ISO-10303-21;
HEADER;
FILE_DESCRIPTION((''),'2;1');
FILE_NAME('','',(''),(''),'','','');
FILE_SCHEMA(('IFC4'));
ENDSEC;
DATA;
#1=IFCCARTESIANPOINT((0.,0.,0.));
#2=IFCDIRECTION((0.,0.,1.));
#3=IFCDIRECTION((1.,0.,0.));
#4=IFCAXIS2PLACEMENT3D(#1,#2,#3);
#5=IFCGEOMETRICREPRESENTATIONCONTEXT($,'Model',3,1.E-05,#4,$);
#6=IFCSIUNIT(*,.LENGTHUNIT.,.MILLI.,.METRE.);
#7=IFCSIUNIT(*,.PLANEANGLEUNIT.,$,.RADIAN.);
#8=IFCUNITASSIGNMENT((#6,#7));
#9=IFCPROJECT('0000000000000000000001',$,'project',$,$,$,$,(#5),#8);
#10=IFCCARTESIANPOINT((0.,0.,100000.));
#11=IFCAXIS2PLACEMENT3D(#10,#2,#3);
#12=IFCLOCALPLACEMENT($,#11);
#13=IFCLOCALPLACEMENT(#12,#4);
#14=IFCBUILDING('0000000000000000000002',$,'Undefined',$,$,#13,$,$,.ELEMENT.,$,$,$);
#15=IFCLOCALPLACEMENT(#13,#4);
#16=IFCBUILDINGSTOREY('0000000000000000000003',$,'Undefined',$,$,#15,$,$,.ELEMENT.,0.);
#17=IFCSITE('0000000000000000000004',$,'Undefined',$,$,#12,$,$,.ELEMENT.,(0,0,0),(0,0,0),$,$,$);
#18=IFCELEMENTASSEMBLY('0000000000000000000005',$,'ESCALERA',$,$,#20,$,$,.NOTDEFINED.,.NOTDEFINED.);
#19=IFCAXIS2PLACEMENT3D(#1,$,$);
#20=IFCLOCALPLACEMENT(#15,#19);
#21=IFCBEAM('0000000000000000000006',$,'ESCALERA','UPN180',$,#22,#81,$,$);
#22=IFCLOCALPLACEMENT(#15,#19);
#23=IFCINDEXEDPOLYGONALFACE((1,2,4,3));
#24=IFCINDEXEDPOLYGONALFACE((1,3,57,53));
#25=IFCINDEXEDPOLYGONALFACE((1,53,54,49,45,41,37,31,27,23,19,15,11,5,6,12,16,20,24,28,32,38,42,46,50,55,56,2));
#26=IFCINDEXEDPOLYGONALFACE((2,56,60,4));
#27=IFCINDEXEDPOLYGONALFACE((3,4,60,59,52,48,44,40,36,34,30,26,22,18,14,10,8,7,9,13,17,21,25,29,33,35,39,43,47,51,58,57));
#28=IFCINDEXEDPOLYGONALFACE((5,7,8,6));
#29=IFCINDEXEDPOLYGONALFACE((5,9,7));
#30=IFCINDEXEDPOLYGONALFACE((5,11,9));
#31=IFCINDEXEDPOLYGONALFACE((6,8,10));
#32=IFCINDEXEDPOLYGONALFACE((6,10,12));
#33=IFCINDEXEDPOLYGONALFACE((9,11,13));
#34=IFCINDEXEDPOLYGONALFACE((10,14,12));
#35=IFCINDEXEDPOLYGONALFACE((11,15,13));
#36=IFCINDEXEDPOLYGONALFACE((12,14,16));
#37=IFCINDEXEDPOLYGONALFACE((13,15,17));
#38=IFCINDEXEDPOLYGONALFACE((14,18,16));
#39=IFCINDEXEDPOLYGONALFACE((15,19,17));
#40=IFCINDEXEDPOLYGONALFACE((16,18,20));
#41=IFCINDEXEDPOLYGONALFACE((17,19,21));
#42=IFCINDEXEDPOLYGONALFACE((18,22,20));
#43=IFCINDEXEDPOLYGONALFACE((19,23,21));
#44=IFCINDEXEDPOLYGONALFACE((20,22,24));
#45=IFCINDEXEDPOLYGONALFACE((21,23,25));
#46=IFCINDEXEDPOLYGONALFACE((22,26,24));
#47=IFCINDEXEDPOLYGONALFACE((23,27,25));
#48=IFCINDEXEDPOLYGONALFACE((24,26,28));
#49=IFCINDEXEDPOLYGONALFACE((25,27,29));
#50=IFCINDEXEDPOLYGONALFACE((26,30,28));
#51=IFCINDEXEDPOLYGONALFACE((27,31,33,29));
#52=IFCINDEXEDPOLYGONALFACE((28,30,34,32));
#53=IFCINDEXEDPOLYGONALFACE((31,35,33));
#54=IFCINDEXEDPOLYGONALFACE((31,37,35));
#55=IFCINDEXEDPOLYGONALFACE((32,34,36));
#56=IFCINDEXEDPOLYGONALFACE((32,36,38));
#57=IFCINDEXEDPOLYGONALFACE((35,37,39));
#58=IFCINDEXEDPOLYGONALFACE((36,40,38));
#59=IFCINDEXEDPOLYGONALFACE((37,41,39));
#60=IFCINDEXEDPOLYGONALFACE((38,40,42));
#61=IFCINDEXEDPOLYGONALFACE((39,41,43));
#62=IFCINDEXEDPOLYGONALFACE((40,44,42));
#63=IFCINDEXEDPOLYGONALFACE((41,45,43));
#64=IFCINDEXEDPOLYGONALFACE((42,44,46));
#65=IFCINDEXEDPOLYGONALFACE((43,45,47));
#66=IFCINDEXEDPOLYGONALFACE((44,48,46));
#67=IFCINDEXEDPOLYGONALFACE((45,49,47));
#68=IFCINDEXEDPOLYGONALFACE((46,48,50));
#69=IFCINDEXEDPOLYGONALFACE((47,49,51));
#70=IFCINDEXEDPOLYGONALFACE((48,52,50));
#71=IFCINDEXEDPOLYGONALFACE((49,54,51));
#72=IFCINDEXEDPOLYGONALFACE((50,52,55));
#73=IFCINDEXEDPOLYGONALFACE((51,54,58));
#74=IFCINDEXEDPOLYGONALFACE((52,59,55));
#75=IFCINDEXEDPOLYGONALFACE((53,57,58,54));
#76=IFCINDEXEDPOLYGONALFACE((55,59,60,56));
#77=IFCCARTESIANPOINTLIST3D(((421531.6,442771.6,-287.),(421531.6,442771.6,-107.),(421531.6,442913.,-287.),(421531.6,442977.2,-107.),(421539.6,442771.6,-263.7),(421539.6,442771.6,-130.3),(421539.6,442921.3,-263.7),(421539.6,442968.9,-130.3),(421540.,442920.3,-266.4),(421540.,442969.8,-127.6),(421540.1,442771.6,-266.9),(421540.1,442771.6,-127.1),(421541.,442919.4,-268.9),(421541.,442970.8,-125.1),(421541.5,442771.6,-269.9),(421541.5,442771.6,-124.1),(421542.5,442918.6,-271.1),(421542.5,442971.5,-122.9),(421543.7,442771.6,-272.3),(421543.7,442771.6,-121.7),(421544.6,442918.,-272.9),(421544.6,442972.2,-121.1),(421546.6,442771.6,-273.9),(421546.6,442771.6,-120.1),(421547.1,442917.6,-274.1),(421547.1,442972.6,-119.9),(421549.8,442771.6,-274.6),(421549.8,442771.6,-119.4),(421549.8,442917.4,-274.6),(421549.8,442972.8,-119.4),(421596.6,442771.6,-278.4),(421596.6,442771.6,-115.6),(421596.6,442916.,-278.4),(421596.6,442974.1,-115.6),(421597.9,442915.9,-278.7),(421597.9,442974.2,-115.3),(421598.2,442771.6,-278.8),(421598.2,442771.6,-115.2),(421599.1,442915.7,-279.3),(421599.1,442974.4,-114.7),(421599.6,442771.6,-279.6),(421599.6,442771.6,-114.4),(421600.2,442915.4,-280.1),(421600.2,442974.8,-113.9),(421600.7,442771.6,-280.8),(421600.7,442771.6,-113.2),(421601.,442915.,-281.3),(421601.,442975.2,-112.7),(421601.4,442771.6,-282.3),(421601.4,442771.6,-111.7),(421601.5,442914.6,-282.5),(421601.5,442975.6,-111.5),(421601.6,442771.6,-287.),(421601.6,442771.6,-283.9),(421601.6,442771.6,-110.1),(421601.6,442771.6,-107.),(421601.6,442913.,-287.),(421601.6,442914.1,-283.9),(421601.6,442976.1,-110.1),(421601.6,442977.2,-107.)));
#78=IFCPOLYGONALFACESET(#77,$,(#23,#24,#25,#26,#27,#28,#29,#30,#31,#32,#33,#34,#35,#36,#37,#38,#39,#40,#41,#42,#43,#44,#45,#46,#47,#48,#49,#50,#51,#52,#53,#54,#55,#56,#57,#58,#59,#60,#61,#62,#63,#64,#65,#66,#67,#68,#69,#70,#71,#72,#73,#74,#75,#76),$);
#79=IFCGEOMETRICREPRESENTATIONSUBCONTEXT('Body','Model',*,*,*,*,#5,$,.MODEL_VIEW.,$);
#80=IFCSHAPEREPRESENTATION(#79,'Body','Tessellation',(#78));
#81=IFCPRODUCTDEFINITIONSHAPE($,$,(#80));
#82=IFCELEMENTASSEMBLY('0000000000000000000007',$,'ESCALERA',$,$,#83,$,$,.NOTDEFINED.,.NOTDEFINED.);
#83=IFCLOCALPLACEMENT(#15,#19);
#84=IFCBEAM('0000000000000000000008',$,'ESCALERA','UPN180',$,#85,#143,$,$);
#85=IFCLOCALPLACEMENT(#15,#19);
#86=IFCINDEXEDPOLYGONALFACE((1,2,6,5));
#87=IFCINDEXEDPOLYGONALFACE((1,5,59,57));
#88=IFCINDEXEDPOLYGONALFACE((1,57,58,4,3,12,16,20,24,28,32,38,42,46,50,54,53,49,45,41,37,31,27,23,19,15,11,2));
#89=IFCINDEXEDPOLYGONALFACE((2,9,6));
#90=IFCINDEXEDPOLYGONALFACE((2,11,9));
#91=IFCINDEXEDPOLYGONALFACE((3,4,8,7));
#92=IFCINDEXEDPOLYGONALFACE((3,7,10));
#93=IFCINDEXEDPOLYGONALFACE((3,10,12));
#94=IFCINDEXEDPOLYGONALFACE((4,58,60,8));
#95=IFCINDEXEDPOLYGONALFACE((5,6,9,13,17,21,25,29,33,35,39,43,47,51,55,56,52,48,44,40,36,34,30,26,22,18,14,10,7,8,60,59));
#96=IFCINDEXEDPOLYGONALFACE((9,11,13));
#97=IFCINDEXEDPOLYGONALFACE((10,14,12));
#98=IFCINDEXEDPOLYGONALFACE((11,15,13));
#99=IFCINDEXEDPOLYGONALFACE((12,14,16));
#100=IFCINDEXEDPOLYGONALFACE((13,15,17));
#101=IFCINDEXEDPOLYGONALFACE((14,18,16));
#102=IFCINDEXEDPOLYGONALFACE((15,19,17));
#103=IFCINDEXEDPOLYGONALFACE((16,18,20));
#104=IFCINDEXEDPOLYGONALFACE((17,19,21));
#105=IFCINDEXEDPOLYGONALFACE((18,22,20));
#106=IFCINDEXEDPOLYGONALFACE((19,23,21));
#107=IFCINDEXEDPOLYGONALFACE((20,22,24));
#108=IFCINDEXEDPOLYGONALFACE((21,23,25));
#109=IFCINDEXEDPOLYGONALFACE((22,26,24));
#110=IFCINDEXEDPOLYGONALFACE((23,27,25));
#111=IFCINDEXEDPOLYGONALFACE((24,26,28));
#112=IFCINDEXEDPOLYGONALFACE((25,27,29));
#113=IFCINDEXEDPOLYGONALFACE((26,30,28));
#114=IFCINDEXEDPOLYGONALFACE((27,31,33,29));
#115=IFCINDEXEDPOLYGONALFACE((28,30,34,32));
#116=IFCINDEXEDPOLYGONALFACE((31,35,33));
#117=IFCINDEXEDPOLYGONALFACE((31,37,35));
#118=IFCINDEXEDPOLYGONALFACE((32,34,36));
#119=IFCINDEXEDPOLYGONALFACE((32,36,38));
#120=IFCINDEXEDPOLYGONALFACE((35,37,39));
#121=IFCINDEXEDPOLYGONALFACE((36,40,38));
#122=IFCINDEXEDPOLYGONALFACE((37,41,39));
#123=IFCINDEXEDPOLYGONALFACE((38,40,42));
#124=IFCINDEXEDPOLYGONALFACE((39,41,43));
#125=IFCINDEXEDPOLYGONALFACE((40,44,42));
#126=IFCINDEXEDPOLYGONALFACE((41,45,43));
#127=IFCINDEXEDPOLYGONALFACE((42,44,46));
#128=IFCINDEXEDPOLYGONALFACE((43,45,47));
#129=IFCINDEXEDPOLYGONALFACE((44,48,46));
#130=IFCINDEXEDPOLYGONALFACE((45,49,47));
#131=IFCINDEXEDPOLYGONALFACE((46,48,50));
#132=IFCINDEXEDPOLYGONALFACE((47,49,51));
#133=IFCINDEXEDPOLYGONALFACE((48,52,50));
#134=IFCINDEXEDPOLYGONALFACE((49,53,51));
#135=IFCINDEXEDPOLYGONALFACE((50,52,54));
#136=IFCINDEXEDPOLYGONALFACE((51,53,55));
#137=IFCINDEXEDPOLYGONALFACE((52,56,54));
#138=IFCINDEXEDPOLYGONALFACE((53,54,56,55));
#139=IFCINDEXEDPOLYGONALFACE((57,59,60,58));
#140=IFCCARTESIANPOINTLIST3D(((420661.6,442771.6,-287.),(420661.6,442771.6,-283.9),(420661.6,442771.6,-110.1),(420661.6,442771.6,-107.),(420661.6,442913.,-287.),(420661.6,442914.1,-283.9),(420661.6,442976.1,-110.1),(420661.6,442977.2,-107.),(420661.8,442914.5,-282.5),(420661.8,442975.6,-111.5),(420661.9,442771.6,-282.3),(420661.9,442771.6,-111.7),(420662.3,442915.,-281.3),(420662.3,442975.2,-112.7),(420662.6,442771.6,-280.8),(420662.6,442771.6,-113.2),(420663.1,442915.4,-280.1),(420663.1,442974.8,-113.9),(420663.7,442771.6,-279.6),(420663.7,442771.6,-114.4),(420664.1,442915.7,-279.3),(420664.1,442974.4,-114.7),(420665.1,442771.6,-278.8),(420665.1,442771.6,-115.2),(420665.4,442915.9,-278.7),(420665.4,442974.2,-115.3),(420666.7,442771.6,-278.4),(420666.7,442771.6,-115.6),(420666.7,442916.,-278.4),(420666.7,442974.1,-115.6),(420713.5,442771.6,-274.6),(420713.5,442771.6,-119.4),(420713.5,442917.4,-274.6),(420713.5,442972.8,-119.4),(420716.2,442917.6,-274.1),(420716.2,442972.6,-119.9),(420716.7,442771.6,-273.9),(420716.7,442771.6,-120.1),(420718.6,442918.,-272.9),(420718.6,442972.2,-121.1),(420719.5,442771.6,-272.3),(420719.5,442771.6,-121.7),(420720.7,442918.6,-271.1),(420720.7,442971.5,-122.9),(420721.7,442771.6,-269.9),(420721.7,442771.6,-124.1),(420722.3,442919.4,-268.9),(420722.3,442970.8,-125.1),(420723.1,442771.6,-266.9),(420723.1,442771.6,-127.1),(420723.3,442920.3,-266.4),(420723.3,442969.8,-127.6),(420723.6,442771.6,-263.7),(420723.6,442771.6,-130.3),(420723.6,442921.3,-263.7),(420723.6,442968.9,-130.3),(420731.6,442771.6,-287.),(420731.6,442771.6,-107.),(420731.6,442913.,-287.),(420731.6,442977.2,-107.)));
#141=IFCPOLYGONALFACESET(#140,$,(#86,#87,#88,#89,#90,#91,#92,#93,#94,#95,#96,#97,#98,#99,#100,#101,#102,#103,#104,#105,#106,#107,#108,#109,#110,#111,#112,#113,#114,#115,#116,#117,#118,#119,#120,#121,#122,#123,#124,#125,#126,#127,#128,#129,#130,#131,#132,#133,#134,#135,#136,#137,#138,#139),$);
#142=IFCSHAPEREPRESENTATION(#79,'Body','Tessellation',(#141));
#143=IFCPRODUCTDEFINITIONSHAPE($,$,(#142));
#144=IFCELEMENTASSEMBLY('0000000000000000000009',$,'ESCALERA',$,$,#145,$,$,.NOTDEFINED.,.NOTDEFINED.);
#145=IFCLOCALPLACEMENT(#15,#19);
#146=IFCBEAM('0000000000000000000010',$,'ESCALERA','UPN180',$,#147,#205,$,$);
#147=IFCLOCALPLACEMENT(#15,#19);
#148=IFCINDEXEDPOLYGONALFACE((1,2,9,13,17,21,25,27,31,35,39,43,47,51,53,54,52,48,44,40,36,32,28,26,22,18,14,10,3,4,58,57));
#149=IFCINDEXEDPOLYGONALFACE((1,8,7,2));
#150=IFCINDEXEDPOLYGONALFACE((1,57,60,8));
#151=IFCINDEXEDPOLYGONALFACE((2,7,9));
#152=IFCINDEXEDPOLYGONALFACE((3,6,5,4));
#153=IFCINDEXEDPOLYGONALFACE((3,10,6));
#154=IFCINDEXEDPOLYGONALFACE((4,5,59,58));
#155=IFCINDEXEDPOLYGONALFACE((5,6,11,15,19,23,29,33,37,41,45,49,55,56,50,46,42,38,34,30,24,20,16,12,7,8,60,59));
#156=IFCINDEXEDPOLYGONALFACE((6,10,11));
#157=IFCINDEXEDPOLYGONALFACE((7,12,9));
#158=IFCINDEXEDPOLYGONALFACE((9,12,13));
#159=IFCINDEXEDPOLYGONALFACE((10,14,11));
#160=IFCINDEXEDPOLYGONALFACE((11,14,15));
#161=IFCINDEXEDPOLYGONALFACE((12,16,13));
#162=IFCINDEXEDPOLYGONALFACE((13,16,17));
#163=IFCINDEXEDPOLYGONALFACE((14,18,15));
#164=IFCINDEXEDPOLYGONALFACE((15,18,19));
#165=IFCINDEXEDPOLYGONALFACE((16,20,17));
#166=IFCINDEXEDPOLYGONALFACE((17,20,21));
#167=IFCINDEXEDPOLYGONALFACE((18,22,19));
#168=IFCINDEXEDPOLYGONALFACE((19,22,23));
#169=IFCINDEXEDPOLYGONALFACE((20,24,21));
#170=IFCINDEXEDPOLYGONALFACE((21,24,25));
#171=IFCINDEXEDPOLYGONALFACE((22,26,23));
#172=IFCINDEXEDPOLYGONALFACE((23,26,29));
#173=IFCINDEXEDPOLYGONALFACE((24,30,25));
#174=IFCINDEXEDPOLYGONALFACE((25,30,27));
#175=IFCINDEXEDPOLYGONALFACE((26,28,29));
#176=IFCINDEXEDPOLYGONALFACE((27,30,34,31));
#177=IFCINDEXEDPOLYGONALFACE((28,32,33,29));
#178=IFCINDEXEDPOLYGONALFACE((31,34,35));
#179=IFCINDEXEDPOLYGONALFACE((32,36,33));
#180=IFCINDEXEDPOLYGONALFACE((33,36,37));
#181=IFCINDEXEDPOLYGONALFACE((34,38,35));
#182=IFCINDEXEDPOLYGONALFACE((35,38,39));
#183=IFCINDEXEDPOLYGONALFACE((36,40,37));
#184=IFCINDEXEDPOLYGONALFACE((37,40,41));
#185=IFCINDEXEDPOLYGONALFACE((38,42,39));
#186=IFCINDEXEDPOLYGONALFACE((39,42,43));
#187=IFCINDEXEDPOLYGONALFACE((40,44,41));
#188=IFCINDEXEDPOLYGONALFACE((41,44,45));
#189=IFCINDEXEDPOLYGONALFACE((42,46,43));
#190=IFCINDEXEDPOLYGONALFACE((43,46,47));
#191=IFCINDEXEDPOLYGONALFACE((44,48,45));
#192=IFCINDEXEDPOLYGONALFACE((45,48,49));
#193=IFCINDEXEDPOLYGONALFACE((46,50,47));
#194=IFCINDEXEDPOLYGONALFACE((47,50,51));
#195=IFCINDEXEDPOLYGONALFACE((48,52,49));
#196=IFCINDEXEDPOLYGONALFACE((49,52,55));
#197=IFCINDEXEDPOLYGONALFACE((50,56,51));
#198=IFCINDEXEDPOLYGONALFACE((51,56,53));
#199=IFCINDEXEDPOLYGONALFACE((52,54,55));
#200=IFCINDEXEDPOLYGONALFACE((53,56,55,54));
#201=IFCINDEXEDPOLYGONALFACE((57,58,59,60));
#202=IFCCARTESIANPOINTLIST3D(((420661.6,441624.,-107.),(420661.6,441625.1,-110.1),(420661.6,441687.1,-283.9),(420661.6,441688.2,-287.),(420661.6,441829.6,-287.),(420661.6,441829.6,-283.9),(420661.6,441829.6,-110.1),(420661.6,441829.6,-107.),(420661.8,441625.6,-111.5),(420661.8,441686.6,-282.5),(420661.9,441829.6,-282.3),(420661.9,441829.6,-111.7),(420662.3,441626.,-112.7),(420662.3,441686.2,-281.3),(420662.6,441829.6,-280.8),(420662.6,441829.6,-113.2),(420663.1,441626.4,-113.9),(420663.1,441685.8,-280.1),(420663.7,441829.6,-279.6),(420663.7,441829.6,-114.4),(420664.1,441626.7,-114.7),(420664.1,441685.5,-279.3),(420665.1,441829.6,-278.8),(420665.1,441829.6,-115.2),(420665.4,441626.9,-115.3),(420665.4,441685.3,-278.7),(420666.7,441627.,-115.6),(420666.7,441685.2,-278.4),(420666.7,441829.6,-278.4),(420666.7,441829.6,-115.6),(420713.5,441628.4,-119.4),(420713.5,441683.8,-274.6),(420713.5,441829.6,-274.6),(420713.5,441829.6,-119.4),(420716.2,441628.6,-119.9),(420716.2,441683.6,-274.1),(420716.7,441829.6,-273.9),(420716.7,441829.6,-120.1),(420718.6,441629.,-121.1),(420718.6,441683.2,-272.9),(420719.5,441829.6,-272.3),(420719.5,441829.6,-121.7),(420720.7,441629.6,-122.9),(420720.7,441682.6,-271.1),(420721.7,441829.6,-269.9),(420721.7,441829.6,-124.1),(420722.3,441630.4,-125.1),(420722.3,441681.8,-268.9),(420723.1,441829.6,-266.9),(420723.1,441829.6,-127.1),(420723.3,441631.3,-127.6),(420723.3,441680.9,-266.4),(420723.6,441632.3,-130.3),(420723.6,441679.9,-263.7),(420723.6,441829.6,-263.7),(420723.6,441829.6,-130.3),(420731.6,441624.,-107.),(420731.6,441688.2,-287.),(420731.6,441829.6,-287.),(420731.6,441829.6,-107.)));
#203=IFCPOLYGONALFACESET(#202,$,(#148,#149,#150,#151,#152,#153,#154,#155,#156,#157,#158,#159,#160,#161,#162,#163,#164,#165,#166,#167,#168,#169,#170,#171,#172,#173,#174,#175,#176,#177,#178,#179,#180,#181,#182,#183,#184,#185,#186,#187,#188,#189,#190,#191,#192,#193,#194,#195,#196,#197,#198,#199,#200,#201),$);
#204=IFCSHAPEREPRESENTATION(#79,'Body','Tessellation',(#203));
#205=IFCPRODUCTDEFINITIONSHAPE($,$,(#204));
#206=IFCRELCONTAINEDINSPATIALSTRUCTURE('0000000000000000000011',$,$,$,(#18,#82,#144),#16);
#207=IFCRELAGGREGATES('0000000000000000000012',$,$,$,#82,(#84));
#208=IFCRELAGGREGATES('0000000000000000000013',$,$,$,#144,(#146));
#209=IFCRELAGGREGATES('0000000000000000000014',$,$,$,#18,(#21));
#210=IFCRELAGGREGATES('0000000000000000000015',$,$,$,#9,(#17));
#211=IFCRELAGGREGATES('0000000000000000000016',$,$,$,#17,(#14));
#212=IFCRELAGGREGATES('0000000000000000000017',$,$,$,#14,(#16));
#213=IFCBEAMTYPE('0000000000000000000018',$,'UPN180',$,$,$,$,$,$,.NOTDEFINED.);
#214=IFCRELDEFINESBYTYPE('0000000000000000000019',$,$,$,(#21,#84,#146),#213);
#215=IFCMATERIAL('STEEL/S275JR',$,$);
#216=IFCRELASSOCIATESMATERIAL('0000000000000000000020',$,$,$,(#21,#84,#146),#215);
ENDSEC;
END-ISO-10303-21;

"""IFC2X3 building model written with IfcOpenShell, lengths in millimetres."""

from ifc_helpers import new_model, si_unit, frame, origin_with_axes, origin_2d_with_axis, place, context, subcontext, project, spatial, u_section, extrude, clip, halfspace, material, type_object, element, aggregate, save


model = new_model("IFC2X3")

# Units and contexts
model_context = context("Model", 3, precision=1e-05, world=origin_with_axes())
body_context = subcontext(model_context, "Body", "Model", "MODEL_VIEW")
ifc_project = project(units=[si_unit("LENGTHUNIT", "METRE", prefix="MILLI"), si_unit("PLANEANGLEUNIT", "RADIAN")], contexts=[model_context])

# Site, building, storey
site_placement = place(None, frame((0.0, 0.0, 100000.0), z_axis=(0.0, 0.0, 1.0), x_axis=(1.0, 0.0, 0.0)))
site = spatial("IfcSite", under=ifc_project, at=site_placement, Name="Undefined", CompositionType="ELEMENT", RefLatitude=(0, 0, 0), RefLongitude=(0, 0, 0))
building_placement = place(site_placement, origin_with_axes())
building = spatial("IfcBuilding", under=site, at=building_placement, Name="Undefined", CompositionType="ELEMENT")
storey_placement = place(building_placement, origin_with_axes())
storey = spatial("IfcBuildingStorey", under=building, at=storey_placement, Name="Undefined", CompositionType="ELEMENT", Elevation=0.0)

# Shared definitions
ifc_material_1 = material(Name="STEEL/S275JR")

# Element assemblies, beams
beam_type_1 = type_object("IfcBeamType", Name="UPN180", PredefinedType="NOTDEFINED")
assembly_1_placement = place(storey_placement, origin_with_axes())
assembly_1 = element("IfcElementAssembly", 1, at=assembly_1_placement, inside=storey, Name="ESCALERA", AssemblyPlace="NOTDEFINED", PredefinedType="NOTDEFINED")
beam_1_placement = place(assembly_1_placement, frame((421566.6, 442771.6, -197.0), z_axis=(0.0, 0.0, 1.0), x_axis=(-0.000001, 1.0, 0.0)))
beam_1 = element("IfcBeam", 2, at=beam_1_placement, type_object=beam_type_1, material=ifc_material_1, Name="ESCALERA", Description="UPN180", context=body_context, shape_type="Clipping", body=[
    clip(extrude(u_section(Depth=180.0, FlangeWidth=70.0, WebThickness=8.0, FlangeThickness=11.0, FilletRadius=11.0, EdgeRadius=5.5, FlangeSlope=0.07983, at=origin_2d_with_axis()), frame((206.0, 0.0, 0.0), z_axis=(-1.0, 0.0, 0.0), x_axis=(0.0, -1.0, 0.0)), (0.0, 0.0, 1.0), 206.0), halfspace(frame((205.6, -35.0, 90.0), z_axis=(-0.941795, 0.0, 0.336186), x_axis=(0.0, -1.0, 0.0)), True)),
])
assembly_2_placement = place(storey_placement, origin_with_axes())
assembly_2 = element("IfcElementAssembly", 3, at=assembly_2_placement, inside=storey, Name="ESCALERA", AssemblyPlace="NOTDEFINED", PredefinedType="NOTDEFINED")
beam_2_placement = place(assembly_2_placement, frame((420696.6, 442977.2, -197.0), z_axis=(0.0, 0.0, 1.0), x_axis=(0.000001, -1.0, 0.0)))
beam_2 = element("IfcBeam", 4, at=beam_2_placement, type_object=beam_type_1, material=ifc_material_1, Name="ESCALERA", Description="UPN180", context=body_context, shape_type="Clipping", body=[
    clip(extrude(u_section(Depth=180.0, FlangeWidth=70.0, WebThickness=8.0, FlangeThickness=11.0, FilletRadius=11.0, EdgeRadius=5.5, FlangeSlope=0.07983, at=origin_2d_with_axis()), frame((205.6, 0.0, 0.0), z_axis=(-1.0, 0.0, 0.0), x_axis=(0.0, -1.0, 0.0)), (0.0, 0.0, 1.0), 206.0), halfspace(frame((0.0, -35.0, 90.0), z_axis=(-0.941795, 0.0, -0.336186), x_axis=(0.0, -1.0, 0.0)), False)),
])
aggregate(assembly_2, [beam_2])
assembly_3_placement = place(storey_placement, origin_with_axes())
assembly_3 = element("IfcElementAssembly", 5, at=assembly_3_placement, inside=storey, Name="ESCALERA", AssemblyPlace="NOTDEFINED", PredefinedType="NOTDEFINED")
beam_3_placement = place(assembly_3_placement, frame((420696.6, 441829.6, -197.0), z_axis=(0.0, 0.0, 1.0), x_axis=(-0.000001, -1.0, 0.0)))
beam_3 = element("IfcBeam", 6, at=beam_3_placement, type_object=beam_type_1, material=ifc_material_1, Name="ESCALERA", Description="UPN180", context=body_context, shape_type="Clipping", body=[
    clip(extrude(u_section(Depth=180.0, FlangeWidth=70.0, WebThickness=8.0, FlangeThickness=11.0, FilletRadius=11.0, EdgeRadius=5.5, FlangeSlope=0.07983, at=origin_2d_with_axis()), frame((206.0, 0.0, 0.0), z_axis=(-1.0, 0.0, 0.0), x_axis=(0.0, -1.0, 0.0)), (0.0, 0.0, 1.0), 206.0), halfspace(frame((205.6, -35.0, 90.0), z_axis=(-0.941795, 0.0, 0.336186), x_axis=(0.0, -1.0, 0.0)), True)),
])
aggregate(assembly_3, [beam_3])

aggregate(assembly_1, [beam_1])

save(model, "model.ifc")
